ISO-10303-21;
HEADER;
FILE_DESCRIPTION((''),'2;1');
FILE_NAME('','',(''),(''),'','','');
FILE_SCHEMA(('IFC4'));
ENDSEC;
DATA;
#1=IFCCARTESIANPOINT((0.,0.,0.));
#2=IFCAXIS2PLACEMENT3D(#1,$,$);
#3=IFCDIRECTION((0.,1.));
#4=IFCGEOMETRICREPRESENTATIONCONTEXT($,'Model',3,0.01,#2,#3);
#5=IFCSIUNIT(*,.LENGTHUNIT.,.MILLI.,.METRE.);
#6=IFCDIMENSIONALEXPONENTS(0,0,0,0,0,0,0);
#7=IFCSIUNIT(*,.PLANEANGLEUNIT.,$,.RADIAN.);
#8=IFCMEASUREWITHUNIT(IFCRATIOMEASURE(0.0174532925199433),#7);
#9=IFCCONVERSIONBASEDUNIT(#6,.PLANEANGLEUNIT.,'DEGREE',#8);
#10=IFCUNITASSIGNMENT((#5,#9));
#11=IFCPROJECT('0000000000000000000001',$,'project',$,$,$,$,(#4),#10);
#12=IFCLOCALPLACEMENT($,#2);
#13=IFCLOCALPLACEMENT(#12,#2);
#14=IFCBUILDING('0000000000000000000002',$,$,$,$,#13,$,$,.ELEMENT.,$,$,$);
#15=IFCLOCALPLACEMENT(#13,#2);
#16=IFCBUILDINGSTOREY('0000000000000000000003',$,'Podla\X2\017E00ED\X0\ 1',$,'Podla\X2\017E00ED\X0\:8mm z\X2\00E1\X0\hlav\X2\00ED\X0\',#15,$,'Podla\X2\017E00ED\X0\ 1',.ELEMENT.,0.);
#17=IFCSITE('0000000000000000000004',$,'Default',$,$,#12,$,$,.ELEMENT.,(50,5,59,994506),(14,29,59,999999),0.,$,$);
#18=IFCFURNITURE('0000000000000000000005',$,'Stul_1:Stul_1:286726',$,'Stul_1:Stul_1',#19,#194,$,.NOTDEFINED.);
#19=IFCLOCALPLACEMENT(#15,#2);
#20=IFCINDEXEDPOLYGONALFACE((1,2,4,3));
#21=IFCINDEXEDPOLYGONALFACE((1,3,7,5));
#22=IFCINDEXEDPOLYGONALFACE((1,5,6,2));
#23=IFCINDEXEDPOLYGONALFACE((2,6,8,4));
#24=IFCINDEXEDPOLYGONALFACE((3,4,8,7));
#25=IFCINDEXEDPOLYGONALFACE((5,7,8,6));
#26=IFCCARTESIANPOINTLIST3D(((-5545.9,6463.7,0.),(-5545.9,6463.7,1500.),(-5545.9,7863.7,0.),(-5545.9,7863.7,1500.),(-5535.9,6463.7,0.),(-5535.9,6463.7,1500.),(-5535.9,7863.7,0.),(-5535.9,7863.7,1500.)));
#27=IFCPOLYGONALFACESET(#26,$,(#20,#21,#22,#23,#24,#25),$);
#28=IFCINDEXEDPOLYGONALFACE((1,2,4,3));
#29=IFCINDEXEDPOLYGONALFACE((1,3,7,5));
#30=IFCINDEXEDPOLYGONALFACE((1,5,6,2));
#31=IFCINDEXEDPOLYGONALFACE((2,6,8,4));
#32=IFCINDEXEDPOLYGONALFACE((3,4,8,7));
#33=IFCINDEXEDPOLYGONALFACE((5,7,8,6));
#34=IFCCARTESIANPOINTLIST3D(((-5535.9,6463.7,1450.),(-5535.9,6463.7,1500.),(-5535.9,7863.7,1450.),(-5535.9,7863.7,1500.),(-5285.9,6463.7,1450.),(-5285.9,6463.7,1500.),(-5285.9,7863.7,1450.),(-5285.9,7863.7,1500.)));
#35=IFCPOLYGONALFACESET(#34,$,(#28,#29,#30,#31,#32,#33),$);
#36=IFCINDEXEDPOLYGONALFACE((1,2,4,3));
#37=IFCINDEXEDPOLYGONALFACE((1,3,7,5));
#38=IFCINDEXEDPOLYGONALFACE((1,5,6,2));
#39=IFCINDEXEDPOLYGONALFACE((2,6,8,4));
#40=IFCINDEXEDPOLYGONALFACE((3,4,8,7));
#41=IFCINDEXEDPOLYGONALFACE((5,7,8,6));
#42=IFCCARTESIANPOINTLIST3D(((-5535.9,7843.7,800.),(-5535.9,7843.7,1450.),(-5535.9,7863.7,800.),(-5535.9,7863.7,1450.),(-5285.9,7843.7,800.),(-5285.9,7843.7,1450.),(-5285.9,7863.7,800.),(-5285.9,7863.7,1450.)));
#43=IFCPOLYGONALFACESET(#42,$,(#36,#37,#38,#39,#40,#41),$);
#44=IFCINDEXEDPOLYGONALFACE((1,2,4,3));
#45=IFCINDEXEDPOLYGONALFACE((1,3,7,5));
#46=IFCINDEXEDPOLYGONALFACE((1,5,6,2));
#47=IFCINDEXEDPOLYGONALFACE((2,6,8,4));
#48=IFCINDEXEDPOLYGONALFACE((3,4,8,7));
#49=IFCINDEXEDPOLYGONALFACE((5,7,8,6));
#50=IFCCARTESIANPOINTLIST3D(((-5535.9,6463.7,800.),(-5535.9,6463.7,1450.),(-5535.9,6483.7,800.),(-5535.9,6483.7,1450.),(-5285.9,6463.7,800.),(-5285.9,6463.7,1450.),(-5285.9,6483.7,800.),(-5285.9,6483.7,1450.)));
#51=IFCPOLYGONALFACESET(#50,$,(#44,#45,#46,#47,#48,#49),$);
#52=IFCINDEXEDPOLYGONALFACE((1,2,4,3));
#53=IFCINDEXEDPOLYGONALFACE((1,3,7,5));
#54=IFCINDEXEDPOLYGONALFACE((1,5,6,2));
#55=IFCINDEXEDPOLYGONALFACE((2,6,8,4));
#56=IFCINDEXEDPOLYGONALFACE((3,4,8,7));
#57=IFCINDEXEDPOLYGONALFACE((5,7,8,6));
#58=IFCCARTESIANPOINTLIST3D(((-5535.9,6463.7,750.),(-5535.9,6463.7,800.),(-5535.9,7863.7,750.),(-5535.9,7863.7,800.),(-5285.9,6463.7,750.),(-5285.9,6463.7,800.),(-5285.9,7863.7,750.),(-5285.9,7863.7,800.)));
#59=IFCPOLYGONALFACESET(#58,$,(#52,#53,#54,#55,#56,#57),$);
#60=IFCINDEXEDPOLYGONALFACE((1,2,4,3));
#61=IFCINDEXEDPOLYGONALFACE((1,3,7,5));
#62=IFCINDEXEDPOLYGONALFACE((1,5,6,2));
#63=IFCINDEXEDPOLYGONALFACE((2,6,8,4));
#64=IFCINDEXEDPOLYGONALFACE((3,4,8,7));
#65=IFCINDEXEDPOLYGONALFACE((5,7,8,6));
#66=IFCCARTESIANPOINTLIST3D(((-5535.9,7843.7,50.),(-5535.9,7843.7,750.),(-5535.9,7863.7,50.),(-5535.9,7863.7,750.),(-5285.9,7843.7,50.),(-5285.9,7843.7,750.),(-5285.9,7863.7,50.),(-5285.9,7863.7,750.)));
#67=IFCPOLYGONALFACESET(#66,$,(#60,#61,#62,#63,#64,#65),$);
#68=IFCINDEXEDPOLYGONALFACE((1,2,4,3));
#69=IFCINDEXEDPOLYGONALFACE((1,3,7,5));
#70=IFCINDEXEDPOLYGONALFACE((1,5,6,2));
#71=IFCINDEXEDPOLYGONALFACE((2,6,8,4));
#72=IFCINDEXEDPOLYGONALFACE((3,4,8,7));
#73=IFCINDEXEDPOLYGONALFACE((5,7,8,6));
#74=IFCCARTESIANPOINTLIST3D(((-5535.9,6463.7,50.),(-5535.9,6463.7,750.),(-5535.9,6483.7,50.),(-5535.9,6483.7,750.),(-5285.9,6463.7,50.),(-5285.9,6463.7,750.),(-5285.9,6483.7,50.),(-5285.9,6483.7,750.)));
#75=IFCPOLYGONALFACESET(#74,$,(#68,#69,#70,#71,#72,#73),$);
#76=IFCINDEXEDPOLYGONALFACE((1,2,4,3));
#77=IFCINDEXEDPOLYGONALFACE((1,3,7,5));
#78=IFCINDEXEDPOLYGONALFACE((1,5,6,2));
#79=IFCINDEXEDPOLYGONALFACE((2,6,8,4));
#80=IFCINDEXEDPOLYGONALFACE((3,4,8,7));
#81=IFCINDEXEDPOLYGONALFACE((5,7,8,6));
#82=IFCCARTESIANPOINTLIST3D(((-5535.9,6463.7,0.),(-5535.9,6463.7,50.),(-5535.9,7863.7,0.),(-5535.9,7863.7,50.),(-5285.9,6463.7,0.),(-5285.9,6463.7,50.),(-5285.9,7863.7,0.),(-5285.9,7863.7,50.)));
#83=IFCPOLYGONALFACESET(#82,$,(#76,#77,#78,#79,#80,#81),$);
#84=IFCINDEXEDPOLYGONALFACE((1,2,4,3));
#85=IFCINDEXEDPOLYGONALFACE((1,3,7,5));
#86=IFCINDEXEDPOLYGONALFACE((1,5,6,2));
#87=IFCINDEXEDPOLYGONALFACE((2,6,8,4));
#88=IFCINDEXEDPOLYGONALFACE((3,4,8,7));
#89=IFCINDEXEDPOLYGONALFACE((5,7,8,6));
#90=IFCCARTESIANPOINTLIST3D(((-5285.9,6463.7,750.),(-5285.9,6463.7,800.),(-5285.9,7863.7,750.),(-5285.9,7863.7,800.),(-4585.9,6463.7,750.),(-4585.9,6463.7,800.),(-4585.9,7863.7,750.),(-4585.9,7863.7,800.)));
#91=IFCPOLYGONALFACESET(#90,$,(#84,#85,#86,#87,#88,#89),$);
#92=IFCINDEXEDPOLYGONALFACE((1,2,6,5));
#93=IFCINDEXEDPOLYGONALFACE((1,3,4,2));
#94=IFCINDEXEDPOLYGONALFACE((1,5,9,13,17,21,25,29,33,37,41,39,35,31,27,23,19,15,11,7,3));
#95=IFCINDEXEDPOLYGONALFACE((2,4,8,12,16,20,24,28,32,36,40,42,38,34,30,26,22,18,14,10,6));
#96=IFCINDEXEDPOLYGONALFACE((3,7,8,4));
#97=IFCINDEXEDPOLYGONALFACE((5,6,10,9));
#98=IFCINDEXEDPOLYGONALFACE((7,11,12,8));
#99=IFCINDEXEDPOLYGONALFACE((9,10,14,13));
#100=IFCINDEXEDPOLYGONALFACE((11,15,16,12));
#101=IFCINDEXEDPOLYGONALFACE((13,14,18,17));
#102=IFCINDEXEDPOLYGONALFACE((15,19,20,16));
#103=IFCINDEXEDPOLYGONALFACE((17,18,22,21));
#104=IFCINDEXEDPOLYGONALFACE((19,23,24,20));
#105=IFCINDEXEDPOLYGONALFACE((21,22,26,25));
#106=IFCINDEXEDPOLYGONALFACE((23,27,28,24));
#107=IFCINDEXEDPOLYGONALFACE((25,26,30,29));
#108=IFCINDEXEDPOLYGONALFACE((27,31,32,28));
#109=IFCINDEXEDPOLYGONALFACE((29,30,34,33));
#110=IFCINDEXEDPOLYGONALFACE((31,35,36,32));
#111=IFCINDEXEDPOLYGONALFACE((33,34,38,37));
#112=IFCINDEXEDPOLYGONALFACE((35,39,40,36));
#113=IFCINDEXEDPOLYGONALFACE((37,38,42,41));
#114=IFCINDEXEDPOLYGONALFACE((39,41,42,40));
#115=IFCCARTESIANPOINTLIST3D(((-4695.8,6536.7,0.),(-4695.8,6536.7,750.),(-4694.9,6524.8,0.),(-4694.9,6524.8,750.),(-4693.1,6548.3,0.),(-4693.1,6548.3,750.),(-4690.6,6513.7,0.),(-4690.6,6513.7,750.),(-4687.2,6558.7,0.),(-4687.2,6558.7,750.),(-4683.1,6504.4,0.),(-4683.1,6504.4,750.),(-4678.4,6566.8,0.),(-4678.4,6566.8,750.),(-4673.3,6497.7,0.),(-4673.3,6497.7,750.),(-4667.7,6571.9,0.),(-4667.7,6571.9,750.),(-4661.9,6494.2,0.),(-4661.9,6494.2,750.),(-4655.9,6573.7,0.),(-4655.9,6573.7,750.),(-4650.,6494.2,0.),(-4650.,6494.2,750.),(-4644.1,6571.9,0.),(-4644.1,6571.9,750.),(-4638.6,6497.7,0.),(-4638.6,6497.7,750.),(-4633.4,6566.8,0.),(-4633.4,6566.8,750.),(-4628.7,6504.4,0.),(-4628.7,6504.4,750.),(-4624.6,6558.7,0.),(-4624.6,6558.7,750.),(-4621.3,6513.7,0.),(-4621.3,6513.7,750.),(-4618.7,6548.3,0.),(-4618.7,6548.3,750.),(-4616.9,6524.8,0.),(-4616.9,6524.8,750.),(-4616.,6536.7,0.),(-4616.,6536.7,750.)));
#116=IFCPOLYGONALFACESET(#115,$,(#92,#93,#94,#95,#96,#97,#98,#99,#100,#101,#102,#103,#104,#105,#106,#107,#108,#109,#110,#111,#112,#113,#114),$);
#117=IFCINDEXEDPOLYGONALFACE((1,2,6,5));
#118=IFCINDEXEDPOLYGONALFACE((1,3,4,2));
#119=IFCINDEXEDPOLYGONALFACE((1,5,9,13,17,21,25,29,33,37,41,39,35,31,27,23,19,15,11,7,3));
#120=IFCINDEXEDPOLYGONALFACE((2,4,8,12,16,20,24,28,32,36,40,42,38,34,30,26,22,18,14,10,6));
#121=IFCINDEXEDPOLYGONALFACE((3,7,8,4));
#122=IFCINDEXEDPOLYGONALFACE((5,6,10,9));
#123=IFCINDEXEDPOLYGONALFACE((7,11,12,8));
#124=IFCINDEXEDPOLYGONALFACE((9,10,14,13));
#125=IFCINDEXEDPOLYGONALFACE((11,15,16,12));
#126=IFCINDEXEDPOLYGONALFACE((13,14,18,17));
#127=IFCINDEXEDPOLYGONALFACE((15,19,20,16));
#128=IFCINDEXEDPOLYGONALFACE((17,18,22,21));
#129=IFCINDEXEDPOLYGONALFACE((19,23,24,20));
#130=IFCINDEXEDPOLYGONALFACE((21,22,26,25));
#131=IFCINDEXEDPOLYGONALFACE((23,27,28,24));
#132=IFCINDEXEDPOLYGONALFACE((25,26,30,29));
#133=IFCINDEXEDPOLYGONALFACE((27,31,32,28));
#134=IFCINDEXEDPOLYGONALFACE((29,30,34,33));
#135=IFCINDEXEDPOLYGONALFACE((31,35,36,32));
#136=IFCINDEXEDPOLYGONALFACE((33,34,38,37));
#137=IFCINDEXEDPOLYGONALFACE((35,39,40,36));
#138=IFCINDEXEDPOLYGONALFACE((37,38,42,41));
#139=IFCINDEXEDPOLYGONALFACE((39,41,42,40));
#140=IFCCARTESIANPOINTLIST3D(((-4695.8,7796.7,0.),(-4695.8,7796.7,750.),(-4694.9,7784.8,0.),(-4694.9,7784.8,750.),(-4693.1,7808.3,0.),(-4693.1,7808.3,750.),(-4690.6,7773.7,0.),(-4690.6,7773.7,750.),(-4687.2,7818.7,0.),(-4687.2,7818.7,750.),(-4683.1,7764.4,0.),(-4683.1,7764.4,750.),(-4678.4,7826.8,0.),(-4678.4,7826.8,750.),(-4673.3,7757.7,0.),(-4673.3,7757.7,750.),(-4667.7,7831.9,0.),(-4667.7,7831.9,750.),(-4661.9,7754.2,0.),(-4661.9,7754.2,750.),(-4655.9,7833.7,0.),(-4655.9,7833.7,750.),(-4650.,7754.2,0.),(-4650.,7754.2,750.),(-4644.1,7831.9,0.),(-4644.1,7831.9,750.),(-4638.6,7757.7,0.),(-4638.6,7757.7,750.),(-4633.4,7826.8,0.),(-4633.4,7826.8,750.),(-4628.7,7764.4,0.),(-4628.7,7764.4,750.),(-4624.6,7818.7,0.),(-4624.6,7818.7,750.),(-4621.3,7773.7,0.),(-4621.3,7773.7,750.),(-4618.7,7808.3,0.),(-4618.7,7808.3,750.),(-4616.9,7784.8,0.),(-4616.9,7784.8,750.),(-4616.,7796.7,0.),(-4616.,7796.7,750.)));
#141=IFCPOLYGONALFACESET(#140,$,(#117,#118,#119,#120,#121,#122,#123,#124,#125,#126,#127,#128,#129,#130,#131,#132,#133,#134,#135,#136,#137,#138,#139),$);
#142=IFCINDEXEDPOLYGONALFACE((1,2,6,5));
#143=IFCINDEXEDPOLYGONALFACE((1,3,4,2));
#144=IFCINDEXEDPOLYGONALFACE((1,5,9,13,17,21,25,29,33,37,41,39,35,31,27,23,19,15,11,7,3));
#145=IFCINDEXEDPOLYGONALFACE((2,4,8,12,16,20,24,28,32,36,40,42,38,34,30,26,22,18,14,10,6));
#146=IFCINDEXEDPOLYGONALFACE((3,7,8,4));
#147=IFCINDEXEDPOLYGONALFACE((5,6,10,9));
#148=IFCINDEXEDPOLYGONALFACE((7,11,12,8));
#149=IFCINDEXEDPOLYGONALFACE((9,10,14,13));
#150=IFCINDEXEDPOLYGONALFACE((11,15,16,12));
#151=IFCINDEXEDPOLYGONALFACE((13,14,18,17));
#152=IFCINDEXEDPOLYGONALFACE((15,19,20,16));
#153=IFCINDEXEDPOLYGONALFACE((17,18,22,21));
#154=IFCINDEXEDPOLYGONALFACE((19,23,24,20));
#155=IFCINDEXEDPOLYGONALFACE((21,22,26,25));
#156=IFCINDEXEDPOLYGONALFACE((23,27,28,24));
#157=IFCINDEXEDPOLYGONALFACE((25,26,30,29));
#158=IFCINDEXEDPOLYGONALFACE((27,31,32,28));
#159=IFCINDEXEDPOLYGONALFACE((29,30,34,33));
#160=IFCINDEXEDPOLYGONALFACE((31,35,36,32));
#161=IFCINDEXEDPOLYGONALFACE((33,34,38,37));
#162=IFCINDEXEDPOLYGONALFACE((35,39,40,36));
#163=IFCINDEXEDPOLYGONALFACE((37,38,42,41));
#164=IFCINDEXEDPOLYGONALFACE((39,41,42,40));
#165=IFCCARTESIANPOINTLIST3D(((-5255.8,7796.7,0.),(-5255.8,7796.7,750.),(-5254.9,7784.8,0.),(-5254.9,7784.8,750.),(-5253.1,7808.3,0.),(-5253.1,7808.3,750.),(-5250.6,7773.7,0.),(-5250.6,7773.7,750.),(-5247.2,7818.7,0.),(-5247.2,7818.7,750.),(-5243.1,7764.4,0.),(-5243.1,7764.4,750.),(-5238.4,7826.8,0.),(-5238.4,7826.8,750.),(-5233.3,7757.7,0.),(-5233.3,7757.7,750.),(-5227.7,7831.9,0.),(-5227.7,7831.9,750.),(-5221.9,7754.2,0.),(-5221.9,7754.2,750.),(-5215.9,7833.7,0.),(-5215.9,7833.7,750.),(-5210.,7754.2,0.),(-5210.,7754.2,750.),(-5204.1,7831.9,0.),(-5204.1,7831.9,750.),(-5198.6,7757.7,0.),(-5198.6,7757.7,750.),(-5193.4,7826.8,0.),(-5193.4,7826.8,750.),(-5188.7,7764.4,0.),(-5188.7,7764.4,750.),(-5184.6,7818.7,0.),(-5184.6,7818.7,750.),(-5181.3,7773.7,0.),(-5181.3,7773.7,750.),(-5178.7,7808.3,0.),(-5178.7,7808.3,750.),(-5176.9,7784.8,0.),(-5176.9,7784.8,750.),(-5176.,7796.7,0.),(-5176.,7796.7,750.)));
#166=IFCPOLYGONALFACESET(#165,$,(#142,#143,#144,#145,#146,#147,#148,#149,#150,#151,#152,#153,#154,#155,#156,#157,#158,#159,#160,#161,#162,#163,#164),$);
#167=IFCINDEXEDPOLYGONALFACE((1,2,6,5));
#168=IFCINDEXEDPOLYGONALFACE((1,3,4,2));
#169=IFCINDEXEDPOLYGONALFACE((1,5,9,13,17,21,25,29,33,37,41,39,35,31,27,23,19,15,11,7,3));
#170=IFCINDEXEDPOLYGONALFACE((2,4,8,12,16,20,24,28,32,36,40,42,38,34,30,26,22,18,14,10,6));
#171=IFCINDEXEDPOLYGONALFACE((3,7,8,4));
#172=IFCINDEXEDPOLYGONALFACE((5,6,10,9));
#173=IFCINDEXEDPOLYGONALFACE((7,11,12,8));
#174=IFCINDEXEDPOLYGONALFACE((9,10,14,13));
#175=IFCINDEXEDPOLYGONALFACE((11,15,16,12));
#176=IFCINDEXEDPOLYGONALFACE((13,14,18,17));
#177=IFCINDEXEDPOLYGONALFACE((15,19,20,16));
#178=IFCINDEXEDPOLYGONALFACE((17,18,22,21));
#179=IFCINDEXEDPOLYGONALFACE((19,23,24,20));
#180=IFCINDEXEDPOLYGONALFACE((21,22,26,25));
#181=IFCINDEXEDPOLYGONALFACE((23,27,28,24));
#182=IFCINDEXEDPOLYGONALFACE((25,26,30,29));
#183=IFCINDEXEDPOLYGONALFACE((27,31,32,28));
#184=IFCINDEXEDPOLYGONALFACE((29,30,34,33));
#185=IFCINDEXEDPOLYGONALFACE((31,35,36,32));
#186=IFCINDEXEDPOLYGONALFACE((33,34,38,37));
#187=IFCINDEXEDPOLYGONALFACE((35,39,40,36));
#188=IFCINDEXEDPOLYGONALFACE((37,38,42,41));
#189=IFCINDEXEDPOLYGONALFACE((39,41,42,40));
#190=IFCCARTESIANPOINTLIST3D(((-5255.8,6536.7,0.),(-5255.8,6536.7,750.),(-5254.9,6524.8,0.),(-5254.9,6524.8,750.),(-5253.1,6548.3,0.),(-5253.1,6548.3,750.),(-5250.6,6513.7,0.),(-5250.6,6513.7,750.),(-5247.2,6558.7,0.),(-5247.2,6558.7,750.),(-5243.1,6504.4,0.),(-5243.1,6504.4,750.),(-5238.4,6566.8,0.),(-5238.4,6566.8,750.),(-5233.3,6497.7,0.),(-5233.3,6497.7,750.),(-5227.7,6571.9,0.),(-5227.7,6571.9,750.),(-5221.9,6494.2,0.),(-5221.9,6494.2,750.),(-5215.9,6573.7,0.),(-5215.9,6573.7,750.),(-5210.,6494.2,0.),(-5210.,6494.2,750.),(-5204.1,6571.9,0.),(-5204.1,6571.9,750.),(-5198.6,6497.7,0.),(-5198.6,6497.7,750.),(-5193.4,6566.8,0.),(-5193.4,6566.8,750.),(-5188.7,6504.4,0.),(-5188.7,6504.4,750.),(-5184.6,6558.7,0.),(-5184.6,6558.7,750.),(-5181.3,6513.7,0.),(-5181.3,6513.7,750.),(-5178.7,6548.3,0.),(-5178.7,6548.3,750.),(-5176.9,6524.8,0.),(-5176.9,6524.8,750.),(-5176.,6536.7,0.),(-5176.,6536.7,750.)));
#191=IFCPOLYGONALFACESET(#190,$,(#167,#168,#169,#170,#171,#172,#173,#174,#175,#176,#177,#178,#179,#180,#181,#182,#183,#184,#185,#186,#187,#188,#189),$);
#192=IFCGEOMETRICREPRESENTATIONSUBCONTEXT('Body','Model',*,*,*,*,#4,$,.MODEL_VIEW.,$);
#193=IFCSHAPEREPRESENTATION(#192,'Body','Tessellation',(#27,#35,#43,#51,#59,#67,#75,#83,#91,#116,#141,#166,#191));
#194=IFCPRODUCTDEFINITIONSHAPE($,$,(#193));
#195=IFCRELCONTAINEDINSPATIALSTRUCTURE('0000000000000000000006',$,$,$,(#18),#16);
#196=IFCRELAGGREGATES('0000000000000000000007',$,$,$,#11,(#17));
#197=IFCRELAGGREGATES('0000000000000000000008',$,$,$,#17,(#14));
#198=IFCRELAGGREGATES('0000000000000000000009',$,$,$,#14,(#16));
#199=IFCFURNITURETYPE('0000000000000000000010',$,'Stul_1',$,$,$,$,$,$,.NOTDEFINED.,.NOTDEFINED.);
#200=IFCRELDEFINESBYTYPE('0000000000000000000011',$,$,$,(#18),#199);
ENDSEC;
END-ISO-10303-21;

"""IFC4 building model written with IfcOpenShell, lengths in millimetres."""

from ifc_helpers import new_model, entity, si_unit, converted_unit, direction, frame, frame_2d, origin, origin_2d_with_axis, place, context, subcontext, project, spatial, rectangle, circle, extrude, source, transform, mapped, type_object, type_shapes, element, save


model = new_model("IFC4")

# Units and contexts
model_context = context("Model", 3, precision=0.01, world=origin(), true_north=direction((0.0, 1.0)))
body_context = subcontext(model_context, "Body", "Model", "MODEL_VIEW")
ifc_project = project(units=[si_unit("LENGTHUNIT", "METRE", prefix="MILLI"), converted_unit("PLANEANGLEUNIT", "DEGREE", entity("IfcRatioMeasure", 0.0174532925199433), si_unit("PLANEANGLEUNIT", "RADIAN"), dimensions=[0, 0, 0, 0, 0, 0, 0])], contexts=[model_context])

# Site, building, storey
site_placement = place(None, origin())
site = spatial("IfcSite", under=ifc_project, at=site_placement, Name="Default", CompositionType="ELEMENT", RefLatitude=(50, 5, 59, 994506), RefLongitude=(14, 29, 59, 999999), RefElevation=0.0)
building_placement = place(site_placement, origin())
building = spatial("IfcBuilding", under=site, at=building_placement, CompositionType="ELEMENT")
storey_placement = place(building_placement, origin())
storey = spatial("IfcBuildingStorey", under=building, at=storey_placement, Name="Podlaží 1", ObjectType="Podlaží:8mm záhlaví", LongName="Podlaží 1", CompositionType="ELEMENT", Elevation=0.0)

# Furniture
furniture_type = type_object("IfcFurnitureType", Name="Stul_1", AssemblyPlace="NOTDEFINED", PredefinedType="NOTDEFINED")
shared_shape_1 = source(origin(), body_context, "Body", "SweptSolid", [
    extrude(rectangle(XDim=1400.0, YDim=10.0, at=origin_2d_with_axis()), frame((0.0, 605.0, 0.0), z_axis=(0.0, 0.0, 1.0), x_axis=(-1.0, 0.0, 0.0)), (0.0, 0.0, 1.0), 1500.0),
    extrude(rectangle(XDim=1400.0, YDim=250.0, at=frame_2d((0.0, 0.0), x_axis=(1.0, 0.0))), frame((0.0, 475.0, 1450.0), z_axis=(0.0, 0.0, 1.0), x_axis=(-1.0, 0.0, 0.0)), (0.0, 0.0, 1.0), 50.0),
    extrude(rectangle(XDim=20.0, YDim=250.0, at=origin_2d_with_axis()), frame((690.0, 475.0, 800.0), z_axis=(0.0, 0.0, 1.0), x_axis=(-1.0, 0.0, 0.0)), (0.0, 0.0, 1.0), 650.0),
    extrude(rectangle(XDim=20.0, YDim=250.0, at=frame_2d((0.0, 0.0), x_axis=(1.0, 0.0))), frame((-690.0, 475.0, 800.0), z_axis=(0.0, 0.0, 1.0), x_axis=(-1.0, 0.0, 0.0)), (0.0, 0.0, 1.0), 650.0),
    extrude(rectangle(XDim=1400.0, YDim=250.0, at=origin_2d_with_axis()), frame((0.0, 475.0, 750.0), z_axis=(0.0, 0.0, 1.0), x_axis=(-1.0, 0.0, 0.0)), (0.0, 0.0, 1.0), 50.0),
    extrude(rectangle(XDim=20.0, YDim=250.0, at=origin_2d_with_axis()), frame((690.0, 475.0, 50.0), z_axis=(0.0, 0.0, 1.0), x_axis=(-1.0, 0.0, 0.0)), (0.0, 0.0, 1.0), 700.0),
    extrude(rectangle(XDim=20.0, YDim=250.0, at=frame_2d((0.0, 0.0), x_axis=(1.0, 0.0))), frame((-690.0, 475.0, 50.0), z_axis=(0.0, 0.0, 1.0), x_axis=(-1.0, 0.0, 0.0)), (0.0, 0.0, 1.0), 700.0),
    extrude(rectangle(XDim=1400.0, YDim=250.0, at=origin_2d_with_axis()), frame((0.0, 475.0, 0.0), z_axis=(0.0, 0.0, 1.0), x_axis=(-1.0, 0.0, 0.0)), (0.0, 0.0, 1.0), 50.0),
    extrude(rectangle(XDim=1400.0, YDim=700.0, at=origin_2d_with_axis()), frame((0.0, 0.0, 750.0), z_axis=(0.0, 0.0, 1.0), x_axis=(-1.0, 0.0, 0.0)), (0.0, 0.0, 1.0), 50.0),
    extrude(circle(Radius=40.0, at=frame_2d((0.0, 0.0), x_axis=(1.0, 0.0))), frame((-630.0, -280.0, 0.0)), (0.0, 0.0, 1.0), 750.0),
    extrude(circle(Radius=40.0, at=frame_2d((0.0, 0.0), x_axis=(1.0, 0.0))), frame((630.0, -280.0, 0.0)), (0.0, 0.0, 1.0), 750.0),
    extrude(circle(Radius=40.0, at=frame_2d((0.0, 0.0), x_axis=(1.0, 0.0))), frame((630.0, 280.0, 0.0)), (0.0, 0.0, 1.0), 750.0),
    extrude(circle(Radius=40.0, at=frame_2d((0.0, 0.0), x_axis=(1.0, 0.0))), frame((-630.0, 280.0, 0.0)), (0.0, 0.0, 1.0), 750.0),
])
type_shapes(furniture_type, [shared_shape_1])
for number, where, z_axis, x_axis, name in (
    (1, (-4935.9, 7163.7, 0.0), (0.0, 0.0, 1.0), (0.0, 1.0, 0.0), "Stul_1:Stul_1:286726"),
):
    element("IfcFurniture", number, at=place(storey_placement, frame(where, z_axis=z_axis, x_axis=x_axis)), inside=storey, type_object=furniture_type, Name=name, ObjectType="Stul_1:Stul_1", PredefinedType="NOTDEFINED", context=body_context, shape_type="MappedRepresentation", body=[
        mapped(shared_shape_1, transform((0.0, 0.0, 0.0), scale=1.0)),
    ])

save(model, "model.ifc")
